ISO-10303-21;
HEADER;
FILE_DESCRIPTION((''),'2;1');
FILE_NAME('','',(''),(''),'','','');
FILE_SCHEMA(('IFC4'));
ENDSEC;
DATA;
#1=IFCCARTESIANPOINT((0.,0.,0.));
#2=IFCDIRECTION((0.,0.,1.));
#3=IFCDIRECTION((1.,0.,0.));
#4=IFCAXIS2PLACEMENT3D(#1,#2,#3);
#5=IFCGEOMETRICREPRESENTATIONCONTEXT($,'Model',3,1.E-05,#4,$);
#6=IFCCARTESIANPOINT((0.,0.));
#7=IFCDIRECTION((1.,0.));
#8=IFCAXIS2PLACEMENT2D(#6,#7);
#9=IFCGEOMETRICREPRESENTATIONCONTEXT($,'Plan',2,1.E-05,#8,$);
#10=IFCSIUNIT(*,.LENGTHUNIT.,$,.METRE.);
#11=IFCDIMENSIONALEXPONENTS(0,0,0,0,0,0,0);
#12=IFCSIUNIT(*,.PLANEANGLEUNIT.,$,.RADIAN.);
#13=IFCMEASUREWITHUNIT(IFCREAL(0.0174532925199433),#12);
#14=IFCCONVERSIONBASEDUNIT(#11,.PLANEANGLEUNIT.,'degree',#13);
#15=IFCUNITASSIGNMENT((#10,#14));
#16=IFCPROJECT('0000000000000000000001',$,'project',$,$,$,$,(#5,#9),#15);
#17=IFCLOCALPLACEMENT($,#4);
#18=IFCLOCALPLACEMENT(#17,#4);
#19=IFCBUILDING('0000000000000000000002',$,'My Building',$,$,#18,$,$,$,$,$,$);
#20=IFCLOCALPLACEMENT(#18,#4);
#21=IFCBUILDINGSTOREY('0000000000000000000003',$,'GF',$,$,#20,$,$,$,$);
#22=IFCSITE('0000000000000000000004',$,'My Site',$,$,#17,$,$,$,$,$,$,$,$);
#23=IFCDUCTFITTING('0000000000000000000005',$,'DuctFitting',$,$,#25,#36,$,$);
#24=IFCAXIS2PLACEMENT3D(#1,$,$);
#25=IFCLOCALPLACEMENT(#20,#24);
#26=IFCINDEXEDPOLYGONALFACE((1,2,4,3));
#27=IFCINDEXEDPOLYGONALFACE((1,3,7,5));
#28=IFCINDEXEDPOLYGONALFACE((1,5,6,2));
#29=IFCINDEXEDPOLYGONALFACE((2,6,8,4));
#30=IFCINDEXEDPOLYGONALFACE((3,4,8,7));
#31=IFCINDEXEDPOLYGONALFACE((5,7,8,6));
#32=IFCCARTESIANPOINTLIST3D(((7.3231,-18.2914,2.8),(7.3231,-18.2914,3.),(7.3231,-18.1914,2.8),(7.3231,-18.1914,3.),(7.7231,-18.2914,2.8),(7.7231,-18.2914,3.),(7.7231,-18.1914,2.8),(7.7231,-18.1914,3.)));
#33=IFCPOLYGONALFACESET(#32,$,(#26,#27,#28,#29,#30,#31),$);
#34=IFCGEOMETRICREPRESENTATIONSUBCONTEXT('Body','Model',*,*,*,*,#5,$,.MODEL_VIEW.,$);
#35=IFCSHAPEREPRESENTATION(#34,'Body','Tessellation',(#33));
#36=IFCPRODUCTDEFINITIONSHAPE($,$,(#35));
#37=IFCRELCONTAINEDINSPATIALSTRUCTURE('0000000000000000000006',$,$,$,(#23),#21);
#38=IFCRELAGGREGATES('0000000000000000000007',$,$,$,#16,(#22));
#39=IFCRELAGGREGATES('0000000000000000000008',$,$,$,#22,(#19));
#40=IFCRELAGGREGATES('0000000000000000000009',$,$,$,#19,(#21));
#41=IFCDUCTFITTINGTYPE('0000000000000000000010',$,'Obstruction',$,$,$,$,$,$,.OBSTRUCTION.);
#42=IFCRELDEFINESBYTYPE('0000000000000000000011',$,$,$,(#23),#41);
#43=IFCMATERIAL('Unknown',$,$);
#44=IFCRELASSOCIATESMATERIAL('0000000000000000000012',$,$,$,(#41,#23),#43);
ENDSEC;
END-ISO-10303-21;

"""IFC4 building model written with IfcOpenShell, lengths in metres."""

from ifc_helpers import new_model, entity, si_unit, converted_unit, frame, origin_with_axes, origin_2d_with_axis, place, context, subcontext, project, spatial, rectangle, extrude, material, material_profile, profile_set, profile_usage, type_object, element, save


model = new_model("IFC4")

# Units and contexts
model_context = context("Model", 3, precision=1e-05, world=origin_with_axes())
plan_context = context("Plan", 2, precision=1e-05, world=origin_2d_with_axis())
body_context_1 = subcontext(model_context, "Body", "Model", "MODEL_VIEW")
ifc_project = project(units=[si_unit("LENGTHUNIT", "METRE"), converted_unit("PLANEANGLEUNIT", "degree", entity("IfcReal", 0.0174532925199433), si_unit("PLANEANGLEUNIT", "RADIAN"), dimensions=[0, 0, 0, 0, 0, 0, 0])], contexts=[model_context, plan_context])

# Site, building, storey
site_placement = place(None, origin_with_axes())
site = spatial("IfcSite", under=ifc_project, at=site_placement, Name="My Site")
building_placement = place(site_placement, origin_with_axes())
building = spatial("IfcBuilding", under=site, at=building_placement, Name="My Building")
storey_placement = place(building_placement, origin_with_axes())
storey = spatial("IfcBuildingStorey", under=building, at=storey_placement, Name="GF")

# Shared definitions
ifc_material = material(Name="Unknown")

# Duct fitting
ifc_material_profile_1 = material_profile(ifc_material, rectangle(XDim=0.4, YDim=0.2))
ifc_profile_set_1 = profile_set([ifc_material_profile_1])
ifc_profile_usage_1 = profile_usage(ifc_profile_set_1, cardinal=5)
duct_fitting_type = type_object("IfcDuctFittingType", Name="Obstruction", PredefinedType="OBSTRUCTION", material=ifc_profile_set_1)
duct_fitting_placement = place(storey_placement, frame((7.5231, -18.1914, 2.9), z_axis=(0.0, -1.0, 0.0), x_axis=(1.0, 0.0, 0.0)))
element("IfcDuctFitting", 1, at=duct_fitting_placement, inside=storey, type_object=duct_fitting_type, material=ifc_profile_usage_1, Name="DuctFitting", context=body_context_1, shape_type="SweptSolid", body=[
    extrude(rectangle(XDim=0.4, YDim=0.2), origin_with_axes(), (0.0, 0.0, 1.0), 0.1),
])

save(model, "model.ifc")
